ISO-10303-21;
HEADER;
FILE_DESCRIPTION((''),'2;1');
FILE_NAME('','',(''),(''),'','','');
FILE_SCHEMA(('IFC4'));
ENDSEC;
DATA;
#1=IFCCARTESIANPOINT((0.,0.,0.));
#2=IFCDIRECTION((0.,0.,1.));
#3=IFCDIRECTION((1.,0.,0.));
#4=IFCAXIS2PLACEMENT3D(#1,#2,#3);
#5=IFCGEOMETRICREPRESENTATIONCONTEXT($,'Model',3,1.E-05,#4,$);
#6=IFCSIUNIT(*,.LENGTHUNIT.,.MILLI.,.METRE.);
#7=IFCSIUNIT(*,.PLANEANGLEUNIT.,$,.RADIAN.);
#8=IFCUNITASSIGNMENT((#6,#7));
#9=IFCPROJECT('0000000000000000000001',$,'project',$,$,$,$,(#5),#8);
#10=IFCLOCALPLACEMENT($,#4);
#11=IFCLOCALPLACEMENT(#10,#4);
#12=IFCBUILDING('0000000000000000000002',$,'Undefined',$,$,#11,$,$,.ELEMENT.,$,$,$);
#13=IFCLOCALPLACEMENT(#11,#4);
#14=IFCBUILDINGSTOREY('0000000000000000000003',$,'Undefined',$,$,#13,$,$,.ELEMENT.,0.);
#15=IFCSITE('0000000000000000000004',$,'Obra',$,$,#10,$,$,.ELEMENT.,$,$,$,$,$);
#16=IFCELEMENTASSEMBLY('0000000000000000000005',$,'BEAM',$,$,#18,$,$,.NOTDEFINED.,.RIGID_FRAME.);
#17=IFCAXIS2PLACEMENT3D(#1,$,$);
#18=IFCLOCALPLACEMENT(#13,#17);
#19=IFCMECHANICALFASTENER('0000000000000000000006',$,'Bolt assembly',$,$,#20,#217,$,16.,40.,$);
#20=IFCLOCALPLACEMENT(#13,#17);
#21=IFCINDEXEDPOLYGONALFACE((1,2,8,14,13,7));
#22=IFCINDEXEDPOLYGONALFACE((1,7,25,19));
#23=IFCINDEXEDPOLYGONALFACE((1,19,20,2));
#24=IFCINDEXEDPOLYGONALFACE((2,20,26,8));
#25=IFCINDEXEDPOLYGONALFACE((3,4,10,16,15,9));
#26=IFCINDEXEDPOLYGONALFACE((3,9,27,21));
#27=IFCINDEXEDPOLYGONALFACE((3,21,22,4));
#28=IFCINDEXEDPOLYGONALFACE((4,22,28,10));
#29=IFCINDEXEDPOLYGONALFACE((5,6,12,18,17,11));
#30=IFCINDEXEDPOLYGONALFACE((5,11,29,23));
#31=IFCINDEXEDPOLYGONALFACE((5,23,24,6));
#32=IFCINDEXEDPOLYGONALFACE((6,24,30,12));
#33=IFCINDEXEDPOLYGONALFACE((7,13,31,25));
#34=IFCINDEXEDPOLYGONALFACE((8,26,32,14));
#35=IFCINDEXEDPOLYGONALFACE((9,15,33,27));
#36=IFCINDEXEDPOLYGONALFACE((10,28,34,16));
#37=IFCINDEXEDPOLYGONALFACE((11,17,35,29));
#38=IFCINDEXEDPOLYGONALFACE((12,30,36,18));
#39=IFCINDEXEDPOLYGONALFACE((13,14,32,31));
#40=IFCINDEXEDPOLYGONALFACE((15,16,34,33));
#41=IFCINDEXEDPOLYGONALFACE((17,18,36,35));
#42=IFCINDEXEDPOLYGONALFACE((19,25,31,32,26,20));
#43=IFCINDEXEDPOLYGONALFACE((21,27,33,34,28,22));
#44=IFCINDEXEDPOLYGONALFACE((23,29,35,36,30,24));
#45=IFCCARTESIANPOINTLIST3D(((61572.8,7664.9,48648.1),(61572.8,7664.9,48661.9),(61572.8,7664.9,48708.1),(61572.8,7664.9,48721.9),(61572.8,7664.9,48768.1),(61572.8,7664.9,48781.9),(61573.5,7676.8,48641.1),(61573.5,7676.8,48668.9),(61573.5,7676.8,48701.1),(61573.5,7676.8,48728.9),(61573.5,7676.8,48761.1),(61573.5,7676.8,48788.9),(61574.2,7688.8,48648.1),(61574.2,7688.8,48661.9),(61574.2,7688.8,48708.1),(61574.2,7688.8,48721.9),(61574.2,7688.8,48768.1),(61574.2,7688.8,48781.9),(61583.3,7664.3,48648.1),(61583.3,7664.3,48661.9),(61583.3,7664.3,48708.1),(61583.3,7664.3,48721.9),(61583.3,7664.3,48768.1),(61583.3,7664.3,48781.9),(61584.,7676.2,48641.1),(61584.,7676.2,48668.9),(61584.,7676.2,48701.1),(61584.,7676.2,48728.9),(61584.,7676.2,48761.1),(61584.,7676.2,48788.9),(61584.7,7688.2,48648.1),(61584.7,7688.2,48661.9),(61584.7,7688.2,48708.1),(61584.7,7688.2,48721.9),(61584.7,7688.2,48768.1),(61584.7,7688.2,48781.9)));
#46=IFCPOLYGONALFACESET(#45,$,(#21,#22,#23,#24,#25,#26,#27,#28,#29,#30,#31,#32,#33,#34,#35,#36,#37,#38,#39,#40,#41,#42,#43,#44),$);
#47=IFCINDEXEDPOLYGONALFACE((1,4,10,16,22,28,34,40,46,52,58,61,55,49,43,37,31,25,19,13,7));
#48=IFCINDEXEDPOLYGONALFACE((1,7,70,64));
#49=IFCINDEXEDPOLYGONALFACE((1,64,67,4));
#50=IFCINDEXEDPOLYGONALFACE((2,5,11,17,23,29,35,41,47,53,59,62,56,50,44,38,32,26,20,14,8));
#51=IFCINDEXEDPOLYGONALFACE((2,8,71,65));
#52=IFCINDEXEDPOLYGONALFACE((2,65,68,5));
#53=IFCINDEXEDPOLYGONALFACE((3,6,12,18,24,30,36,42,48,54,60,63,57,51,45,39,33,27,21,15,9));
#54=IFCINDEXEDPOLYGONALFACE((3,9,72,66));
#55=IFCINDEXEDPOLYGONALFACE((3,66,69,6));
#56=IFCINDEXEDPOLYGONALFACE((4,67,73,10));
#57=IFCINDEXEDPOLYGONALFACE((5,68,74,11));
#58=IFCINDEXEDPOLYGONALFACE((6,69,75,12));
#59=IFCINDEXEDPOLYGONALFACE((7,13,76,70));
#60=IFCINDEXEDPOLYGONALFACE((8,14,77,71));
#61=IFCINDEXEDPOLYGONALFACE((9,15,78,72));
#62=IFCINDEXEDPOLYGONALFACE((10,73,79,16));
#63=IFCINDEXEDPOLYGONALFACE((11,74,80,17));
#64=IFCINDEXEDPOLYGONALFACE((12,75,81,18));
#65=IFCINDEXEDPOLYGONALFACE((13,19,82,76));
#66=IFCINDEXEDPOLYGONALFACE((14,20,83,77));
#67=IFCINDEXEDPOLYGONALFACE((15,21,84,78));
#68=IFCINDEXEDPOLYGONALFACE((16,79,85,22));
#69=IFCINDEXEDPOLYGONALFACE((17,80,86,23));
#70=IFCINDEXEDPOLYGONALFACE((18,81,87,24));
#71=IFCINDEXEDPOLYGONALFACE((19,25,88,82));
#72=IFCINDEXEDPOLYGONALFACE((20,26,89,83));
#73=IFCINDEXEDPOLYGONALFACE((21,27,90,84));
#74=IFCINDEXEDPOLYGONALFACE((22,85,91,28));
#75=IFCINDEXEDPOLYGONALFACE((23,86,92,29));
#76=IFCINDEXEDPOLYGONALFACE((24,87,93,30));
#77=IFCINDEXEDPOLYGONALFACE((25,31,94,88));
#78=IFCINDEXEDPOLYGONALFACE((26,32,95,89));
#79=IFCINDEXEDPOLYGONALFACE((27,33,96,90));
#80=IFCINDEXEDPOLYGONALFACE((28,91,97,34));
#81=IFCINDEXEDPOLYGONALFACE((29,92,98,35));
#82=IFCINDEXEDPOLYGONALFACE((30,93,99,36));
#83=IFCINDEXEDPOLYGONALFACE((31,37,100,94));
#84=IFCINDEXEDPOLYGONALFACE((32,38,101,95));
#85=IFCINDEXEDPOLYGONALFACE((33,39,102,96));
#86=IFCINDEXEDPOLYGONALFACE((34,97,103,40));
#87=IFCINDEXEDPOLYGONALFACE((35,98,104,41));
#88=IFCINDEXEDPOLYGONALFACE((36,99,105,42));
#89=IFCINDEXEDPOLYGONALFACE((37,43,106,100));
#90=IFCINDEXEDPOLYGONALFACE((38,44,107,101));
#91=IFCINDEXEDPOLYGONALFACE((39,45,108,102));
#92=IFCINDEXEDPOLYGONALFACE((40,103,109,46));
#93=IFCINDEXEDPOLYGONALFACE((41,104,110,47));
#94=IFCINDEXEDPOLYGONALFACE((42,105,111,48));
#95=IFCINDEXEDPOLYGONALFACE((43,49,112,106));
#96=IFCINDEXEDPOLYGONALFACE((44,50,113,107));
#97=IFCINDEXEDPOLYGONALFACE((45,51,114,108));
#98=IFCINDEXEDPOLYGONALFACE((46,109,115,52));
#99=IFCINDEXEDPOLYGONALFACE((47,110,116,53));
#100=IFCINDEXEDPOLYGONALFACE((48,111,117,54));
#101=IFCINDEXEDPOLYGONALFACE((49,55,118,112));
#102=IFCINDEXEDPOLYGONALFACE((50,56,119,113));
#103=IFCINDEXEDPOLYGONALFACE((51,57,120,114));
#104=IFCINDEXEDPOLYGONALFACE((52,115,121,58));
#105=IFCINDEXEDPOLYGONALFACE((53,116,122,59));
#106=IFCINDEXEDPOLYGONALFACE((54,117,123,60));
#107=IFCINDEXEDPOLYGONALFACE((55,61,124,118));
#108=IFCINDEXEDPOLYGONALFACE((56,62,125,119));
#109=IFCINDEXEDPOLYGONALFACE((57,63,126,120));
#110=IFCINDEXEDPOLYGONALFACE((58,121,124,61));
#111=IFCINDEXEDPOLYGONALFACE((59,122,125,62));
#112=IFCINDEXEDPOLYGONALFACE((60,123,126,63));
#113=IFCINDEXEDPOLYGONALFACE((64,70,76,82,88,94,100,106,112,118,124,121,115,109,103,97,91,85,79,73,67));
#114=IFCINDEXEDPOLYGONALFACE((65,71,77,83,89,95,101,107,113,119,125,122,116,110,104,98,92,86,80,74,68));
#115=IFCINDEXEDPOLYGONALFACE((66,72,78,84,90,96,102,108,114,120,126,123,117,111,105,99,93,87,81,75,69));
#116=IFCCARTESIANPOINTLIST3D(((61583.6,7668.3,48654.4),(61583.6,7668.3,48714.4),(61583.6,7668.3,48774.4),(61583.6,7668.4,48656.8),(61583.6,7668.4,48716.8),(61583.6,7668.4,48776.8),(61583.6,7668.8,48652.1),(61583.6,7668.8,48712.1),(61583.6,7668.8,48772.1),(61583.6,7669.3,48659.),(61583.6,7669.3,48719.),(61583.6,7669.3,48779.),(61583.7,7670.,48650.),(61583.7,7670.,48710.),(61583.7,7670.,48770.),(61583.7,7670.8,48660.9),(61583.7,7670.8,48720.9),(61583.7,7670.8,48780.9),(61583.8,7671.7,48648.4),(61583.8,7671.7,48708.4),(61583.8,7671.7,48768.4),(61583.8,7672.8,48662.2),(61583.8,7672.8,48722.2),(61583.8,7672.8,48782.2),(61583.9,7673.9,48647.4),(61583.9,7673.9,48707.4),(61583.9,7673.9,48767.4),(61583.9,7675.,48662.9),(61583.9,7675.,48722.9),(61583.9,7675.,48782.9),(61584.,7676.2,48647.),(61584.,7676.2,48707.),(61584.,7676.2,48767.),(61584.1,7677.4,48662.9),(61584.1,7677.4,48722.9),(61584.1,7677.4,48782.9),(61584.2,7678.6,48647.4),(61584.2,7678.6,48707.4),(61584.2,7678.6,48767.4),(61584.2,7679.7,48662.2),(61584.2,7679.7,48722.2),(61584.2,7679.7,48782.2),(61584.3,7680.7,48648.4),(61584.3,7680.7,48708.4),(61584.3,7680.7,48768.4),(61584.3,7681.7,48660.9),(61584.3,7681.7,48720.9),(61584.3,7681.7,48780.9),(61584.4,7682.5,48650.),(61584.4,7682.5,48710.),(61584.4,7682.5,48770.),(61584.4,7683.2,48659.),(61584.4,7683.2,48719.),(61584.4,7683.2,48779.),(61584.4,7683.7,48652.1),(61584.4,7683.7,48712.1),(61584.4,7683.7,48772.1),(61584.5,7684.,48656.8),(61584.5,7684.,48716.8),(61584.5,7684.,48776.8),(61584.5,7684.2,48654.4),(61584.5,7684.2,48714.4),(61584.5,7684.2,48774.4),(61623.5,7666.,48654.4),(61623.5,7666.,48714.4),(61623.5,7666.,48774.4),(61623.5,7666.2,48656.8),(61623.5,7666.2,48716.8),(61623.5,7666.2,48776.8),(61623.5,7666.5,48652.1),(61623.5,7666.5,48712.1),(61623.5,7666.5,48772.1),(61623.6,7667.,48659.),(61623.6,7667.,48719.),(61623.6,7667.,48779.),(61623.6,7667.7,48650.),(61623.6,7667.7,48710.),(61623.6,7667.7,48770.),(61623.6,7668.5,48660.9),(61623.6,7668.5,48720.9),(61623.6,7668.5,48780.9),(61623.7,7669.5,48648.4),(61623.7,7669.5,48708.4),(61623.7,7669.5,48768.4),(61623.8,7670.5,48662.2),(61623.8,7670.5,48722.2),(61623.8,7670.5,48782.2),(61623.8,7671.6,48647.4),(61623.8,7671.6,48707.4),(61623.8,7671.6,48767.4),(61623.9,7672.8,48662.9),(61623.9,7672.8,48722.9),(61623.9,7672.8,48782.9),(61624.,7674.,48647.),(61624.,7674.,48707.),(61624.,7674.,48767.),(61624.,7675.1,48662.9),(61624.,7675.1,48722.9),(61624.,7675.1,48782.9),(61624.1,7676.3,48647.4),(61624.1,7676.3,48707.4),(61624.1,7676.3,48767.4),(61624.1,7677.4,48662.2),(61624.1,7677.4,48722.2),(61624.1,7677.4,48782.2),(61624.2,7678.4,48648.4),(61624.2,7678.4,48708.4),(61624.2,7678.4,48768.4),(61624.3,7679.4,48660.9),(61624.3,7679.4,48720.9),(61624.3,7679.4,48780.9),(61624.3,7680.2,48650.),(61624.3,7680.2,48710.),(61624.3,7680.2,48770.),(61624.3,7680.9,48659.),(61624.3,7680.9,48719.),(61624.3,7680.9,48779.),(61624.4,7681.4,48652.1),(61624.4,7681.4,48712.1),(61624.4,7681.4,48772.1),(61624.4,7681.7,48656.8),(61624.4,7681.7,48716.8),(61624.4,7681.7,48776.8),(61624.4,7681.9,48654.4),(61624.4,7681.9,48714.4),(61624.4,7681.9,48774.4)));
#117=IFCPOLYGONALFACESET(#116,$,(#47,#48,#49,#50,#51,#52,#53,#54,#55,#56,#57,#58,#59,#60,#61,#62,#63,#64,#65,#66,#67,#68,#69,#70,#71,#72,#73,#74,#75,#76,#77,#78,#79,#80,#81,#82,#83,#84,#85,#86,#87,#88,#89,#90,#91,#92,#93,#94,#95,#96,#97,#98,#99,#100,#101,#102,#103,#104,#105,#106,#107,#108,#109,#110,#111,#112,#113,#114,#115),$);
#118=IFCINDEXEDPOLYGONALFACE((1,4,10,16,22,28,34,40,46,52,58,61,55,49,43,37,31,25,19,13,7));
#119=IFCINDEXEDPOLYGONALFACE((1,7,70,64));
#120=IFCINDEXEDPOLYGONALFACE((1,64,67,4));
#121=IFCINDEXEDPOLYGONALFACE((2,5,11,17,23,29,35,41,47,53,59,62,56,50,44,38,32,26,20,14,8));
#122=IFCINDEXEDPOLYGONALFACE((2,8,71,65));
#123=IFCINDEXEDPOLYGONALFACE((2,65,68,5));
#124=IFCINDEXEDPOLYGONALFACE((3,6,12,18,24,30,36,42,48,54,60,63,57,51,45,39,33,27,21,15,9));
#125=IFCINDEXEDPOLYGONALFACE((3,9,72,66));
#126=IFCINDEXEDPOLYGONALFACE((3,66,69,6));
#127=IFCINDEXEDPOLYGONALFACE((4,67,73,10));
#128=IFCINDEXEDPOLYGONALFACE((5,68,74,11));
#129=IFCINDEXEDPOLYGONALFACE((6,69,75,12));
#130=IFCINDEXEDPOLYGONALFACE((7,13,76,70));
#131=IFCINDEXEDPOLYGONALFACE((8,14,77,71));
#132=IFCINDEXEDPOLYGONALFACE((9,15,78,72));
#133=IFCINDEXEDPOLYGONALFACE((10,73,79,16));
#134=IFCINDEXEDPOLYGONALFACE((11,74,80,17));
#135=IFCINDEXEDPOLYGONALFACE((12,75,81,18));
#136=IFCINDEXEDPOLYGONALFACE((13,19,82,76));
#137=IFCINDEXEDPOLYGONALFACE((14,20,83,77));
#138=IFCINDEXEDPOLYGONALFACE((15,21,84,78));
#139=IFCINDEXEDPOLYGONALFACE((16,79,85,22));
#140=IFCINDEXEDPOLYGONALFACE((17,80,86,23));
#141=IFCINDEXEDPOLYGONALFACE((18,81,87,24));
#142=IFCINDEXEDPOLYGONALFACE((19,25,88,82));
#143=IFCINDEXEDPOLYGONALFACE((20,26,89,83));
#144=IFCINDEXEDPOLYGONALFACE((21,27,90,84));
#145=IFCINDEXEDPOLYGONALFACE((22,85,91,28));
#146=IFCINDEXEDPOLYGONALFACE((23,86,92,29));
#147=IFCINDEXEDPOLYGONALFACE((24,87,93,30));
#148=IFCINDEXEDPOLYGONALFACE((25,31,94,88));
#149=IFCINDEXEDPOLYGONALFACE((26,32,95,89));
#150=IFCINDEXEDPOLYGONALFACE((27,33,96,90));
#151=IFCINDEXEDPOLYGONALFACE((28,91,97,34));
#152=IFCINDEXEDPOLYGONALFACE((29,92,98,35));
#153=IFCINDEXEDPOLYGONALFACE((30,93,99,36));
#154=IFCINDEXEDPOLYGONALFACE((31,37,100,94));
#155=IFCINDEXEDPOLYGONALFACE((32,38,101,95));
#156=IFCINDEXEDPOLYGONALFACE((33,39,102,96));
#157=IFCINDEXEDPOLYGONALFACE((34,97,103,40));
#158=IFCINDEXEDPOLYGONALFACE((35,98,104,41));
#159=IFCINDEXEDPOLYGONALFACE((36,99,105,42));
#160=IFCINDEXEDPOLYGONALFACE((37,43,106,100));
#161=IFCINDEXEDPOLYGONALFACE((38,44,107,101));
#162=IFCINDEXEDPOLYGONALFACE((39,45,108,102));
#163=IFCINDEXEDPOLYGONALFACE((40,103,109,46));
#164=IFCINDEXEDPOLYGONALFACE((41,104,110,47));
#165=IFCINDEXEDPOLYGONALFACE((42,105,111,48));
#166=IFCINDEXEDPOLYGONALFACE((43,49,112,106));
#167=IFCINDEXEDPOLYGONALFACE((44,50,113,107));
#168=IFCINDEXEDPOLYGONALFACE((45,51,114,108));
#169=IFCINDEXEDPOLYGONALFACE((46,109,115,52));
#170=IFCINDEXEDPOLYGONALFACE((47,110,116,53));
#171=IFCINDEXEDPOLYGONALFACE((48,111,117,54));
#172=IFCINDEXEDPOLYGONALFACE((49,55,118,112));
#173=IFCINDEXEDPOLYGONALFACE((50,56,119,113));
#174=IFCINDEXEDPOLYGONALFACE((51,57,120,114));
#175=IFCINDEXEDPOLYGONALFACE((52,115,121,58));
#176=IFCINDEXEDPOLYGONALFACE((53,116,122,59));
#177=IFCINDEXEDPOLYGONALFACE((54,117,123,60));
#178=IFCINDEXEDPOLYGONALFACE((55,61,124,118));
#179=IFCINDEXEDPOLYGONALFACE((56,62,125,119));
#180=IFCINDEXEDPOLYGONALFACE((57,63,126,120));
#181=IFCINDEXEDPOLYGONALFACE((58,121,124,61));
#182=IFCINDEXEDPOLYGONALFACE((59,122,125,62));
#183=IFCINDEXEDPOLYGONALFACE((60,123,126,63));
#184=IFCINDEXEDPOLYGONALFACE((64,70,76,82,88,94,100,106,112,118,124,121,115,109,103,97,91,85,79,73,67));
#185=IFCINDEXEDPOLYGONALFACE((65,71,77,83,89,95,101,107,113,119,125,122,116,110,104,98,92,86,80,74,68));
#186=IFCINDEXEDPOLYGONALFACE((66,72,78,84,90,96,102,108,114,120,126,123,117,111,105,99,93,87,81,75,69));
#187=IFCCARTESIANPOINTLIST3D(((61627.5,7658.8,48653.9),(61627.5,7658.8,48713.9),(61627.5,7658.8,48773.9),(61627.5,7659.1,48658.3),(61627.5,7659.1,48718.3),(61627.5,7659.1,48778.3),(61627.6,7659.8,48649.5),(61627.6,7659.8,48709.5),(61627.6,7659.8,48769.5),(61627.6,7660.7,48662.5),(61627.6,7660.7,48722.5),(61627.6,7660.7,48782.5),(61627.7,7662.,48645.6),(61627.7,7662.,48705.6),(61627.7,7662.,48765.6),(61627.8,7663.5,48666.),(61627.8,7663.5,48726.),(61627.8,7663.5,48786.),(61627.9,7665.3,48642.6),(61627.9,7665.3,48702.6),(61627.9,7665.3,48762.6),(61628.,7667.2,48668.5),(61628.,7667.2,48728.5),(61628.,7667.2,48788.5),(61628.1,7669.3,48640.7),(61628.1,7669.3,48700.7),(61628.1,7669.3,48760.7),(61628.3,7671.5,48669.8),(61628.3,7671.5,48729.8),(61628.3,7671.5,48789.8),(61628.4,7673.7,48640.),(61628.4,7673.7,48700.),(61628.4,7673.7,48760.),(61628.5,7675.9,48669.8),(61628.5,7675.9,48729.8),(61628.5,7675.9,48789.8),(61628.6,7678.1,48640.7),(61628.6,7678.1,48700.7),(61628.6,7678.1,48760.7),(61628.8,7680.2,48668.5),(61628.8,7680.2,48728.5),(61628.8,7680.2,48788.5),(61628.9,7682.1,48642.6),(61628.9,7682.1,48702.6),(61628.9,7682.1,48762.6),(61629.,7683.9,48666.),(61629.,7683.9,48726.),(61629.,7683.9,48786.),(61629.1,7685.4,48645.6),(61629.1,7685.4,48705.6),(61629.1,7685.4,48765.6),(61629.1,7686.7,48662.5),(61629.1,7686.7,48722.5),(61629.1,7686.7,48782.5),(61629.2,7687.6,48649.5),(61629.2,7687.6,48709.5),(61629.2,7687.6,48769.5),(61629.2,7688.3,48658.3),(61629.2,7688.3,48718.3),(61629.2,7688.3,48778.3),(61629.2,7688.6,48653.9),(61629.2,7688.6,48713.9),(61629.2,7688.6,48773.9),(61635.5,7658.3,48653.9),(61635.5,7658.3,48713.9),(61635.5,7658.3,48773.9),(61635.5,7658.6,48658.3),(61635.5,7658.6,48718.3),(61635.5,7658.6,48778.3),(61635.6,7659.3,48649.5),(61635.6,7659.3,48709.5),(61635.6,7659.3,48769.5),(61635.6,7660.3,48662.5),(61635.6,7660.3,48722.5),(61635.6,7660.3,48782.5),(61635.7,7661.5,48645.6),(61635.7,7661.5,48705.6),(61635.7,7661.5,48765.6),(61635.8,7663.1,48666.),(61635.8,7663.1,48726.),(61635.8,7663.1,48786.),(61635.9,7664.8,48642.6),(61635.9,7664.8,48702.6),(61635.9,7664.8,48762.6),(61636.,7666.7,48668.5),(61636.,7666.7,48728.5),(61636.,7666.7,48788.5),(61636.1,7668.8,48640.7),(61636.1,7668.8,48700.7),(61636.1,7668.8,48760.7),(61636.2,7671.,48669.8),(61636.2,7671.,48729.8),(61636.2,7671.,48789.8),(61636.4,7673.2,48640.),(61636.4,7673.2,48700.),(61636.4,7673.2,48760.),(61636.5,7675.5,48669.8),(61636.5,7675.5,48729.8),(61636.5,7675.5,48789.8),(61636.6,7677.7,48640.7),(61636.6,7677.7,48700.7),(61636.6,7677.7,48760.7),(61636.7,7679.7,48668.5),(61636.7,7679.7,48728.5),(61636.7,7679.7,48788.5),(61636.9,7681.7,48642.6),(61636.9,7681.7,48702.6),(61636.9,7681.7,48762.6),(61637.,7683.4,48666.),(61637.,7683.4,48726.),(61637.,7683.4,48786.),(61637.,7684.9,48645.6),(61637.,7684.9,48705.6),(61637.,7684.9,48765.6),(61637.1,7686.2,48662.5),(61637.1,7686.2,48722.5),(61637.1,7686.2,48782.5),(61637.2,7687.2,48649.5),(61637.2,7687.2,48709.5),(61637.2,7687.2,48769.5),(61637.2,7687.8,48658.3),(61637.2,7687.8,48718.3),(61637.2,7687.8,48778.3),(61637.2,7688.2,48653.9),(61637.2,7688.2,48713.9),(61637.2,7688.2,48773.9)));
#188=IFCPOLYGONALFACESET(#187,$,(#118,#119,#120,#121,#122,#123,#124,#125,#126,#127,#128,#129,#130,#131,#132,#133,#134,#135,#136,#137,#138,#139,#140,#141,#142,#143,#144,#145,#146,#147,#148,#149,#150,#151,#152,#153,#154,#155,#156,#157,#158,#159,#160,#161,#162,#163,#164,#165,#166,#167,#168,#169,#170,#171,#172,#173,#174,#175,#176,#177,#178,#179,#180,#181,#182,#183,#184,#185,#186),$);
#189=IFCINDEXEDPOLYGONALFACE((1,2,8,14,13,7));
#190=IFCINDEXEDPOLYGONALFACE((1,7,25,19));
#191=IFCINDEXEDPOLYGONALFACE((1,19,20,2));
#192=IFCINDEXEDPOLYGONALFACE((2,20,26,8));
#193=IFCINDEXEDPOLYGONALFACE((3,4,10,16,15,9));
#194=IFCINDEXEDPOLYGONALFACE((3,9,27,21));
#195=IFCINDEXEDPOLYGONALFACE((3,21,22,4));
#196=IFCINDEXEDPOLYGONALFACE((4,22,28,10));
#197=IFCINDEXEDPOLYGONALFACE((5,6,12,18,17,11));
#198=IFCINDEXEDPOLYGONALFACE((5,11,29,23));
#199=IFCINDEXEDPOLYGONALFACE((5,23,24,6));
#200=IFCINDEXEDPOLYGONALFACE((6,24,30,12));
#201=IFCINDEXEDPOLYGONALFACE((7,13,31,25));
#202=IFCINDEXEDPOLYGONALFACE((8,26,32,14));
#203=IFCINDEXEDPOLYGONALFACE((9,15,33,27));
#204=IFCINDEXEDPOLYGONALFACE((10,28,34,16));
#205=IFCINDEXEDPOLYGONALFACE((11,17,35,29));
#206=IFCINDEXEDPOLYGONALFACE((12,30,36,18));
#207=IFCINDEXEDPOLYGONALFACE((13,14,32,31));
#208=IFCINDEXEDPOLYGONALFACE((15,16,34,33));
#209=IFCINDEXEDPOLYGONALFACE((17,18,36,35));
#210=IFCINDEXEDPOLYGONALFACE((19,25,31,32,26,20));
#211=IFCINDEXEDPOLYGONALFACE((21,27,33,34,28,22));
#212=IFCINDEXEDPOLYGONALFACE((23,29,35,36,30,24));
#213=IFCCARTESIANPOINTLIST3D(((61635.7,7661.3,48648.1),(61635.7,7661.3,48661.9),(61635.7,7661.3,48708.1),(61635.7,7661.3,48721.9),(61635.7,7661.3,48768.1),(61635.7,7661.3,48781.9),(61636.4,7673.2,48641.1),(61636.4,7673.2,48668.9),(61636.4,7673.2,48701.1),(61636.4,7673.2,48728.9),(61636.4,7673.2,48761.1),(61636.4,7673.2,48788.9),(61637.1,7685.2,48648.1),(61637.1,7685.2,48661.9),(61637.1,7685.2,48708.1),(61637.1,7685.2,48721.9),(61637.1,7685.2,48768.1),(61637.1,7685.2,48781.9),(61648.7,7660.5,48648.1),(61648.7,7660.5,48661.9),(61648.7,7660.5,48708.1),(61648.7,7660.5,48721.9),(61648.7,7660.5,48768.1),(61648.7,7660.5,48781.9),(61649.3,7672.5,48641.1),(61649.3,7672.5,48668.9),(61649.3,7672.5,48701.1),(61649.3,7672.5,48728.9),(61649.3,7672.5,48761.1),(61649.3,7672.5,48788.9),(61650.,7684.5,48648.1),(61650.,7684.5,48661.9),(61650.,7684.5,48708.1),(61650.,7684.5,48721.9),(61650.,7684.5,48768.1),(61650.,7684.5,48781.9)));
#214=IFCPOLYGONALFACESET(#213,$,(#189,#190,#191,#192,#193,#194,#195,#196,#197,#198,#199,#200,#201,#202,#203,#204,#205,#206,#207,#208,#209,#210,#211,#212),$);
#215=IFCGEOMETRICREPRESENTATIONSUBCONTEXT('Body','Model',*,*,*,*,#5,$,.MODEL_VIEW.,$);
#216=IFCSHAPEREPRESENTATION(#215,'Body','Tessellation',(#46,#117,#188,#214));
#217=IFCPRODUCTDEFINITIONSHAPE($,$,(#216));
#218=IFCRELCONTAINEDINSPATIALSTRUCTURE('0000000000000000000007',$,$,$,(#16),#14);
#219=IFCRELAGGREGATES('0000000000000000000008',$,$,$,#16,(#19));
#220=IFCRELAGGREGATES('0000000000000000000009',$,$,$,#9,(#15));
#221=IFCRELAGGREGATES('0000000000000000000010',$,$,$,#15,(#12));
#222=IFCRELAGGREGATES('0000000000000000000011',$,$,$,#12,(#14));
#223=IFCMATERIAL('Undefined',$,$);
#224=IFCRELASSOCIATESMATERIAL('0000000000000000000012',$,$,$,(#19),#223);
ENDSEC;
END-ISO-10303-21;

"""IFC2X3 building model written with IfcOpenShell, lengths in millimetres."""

from ifc_helpers import new_model, si_unit, frame, origin_with_axes, origin_2d_with_axis, place, context, subcontext, project, spatial, polyline, circle, outline, extrude, source, transform, mapped, material, element, aggregate, save


model = new_model("IFC2X3")

# Units and contexts
model_context = context("Model", 3, precision=1e-05, world=origin_with_axes())
body_context = subcontext(model_context, "Body", "Model", "MODEL_VIEW")
ifc_project = project(units=[si_unit("LENGTHUNIT", "METRE", prefix="MILLI"), si_unit("PLANEANGLEUNIT", "RADIAN")], contexts=[model_context])

# Site, building, storey
site_placement = place(None, origin_with_axes())
site = spatial("IfcSite", under=ifc_project, at=site_placement, Name="Obra", CompositionType="ELEMENT")
building_placement = place(site_placement, origin_with_axes())
building = spatial("IfcBuilding", under=site, at=building_placement, Name="Undefined", CompositionType="ELEMENT")
storey_placement = place(building_placement, origin_with_axes())
storey = spatial("IfcBuildingStorey", under=building, at=storey_placement, Name="Undefined", CompositionType="ELEMENT", Elevation=0.0)

# Element assembly
assembly_1_placement = place(storey_placement, origin_with_axes())
assembly_1 = element("IfcElementAssembly", 1, at=assembly_1_placement, inside=storey, Name="BEAM", AssemblyPlace="NOTDEFINED", PredefinedType="RIGID_FRAME")

# Shared definitions
ifc_material_1 = material(Name="Undefined")
shared_shape_1 = source(origin_with_axes(), body_context, "Body", "SweptSolid", [
    extrude(outline(polyline([(13.9, 0.0), (6.9, 12.0), (-6.9, 12.0), (-13.9, 0.0), (-6.9, -12.0), (6.9, -12.0), (13.9, 0.0)])), frame((0.0, -19.7, 0.0), z_axis=(0.0, 1.0, 0.0), x_axis=(1.0, 0.0, 0.0)), (0.0, 0.0, 1.0), 10.6),
    extrude(circle(Radius=8.0, at=origin_2d_with_axis()), frame((0.0, -9.1, 0.0), z_axis=(0.0, 1.0, 0.0), x_axis=(1.0, 0.0, 0.0)), (0.0, 0.0, 1.0), 40.0),
    extrude(circle(Radius=15.0, at=origin_2d_with_axis()), frame((0.0, 35.3, 0.0), z_axis=(0.0, 1.0, 0.0), x_axis=(1.0, 0.0, 0.0)), (0.0, 0.0, 1.0), 8.0),
    extrude(outline(polyline([(13.9, 0.0), (6.9, 12.0), (-6.9, 12.0), (-13.9, 0.0), (-6.9, -12.0), (6.9, -12.0), (13.9, 0.0)])), frame((0.0, 43.3, 0.0), z_axis=(0.0, 1.0, 0.0), x_axis=(1.0, 0.0, 0.0)), (0.0, 0.0, 1.0), 13.0),
])

# Mechanical fastener
mechanical_fastener_1_placement = place(assembly_1_placement, frame((61596.0, 7725.6, 48835.0), z_axis=(-0.05711, -0.998368, 0.0), x_axis=(0.0, 0.0, -1.0)))
mechanical_fastener_1 = element("IfcMechanicalFastener", 2, at=mechanical_fastener_1_placement, material=ifc_material_1, Name="Bolt assembly", NominalDiameter=16.0, NominalLength=40.0, context=body_context, shape_type="MappedRepresentation", body=[
    mapped(shared_shape_1, transform((60.0, 0.0, 50.0))),
    mapped(shared_shape_1, transform((120.0, 0.0, 50.0))),
    mapped(shared_shape_1, transform((180.0, 0.0, 50.0))),
])
aggregate(assembly_1, [mechanical_fastener_1])

save(model, "model.ifc")
